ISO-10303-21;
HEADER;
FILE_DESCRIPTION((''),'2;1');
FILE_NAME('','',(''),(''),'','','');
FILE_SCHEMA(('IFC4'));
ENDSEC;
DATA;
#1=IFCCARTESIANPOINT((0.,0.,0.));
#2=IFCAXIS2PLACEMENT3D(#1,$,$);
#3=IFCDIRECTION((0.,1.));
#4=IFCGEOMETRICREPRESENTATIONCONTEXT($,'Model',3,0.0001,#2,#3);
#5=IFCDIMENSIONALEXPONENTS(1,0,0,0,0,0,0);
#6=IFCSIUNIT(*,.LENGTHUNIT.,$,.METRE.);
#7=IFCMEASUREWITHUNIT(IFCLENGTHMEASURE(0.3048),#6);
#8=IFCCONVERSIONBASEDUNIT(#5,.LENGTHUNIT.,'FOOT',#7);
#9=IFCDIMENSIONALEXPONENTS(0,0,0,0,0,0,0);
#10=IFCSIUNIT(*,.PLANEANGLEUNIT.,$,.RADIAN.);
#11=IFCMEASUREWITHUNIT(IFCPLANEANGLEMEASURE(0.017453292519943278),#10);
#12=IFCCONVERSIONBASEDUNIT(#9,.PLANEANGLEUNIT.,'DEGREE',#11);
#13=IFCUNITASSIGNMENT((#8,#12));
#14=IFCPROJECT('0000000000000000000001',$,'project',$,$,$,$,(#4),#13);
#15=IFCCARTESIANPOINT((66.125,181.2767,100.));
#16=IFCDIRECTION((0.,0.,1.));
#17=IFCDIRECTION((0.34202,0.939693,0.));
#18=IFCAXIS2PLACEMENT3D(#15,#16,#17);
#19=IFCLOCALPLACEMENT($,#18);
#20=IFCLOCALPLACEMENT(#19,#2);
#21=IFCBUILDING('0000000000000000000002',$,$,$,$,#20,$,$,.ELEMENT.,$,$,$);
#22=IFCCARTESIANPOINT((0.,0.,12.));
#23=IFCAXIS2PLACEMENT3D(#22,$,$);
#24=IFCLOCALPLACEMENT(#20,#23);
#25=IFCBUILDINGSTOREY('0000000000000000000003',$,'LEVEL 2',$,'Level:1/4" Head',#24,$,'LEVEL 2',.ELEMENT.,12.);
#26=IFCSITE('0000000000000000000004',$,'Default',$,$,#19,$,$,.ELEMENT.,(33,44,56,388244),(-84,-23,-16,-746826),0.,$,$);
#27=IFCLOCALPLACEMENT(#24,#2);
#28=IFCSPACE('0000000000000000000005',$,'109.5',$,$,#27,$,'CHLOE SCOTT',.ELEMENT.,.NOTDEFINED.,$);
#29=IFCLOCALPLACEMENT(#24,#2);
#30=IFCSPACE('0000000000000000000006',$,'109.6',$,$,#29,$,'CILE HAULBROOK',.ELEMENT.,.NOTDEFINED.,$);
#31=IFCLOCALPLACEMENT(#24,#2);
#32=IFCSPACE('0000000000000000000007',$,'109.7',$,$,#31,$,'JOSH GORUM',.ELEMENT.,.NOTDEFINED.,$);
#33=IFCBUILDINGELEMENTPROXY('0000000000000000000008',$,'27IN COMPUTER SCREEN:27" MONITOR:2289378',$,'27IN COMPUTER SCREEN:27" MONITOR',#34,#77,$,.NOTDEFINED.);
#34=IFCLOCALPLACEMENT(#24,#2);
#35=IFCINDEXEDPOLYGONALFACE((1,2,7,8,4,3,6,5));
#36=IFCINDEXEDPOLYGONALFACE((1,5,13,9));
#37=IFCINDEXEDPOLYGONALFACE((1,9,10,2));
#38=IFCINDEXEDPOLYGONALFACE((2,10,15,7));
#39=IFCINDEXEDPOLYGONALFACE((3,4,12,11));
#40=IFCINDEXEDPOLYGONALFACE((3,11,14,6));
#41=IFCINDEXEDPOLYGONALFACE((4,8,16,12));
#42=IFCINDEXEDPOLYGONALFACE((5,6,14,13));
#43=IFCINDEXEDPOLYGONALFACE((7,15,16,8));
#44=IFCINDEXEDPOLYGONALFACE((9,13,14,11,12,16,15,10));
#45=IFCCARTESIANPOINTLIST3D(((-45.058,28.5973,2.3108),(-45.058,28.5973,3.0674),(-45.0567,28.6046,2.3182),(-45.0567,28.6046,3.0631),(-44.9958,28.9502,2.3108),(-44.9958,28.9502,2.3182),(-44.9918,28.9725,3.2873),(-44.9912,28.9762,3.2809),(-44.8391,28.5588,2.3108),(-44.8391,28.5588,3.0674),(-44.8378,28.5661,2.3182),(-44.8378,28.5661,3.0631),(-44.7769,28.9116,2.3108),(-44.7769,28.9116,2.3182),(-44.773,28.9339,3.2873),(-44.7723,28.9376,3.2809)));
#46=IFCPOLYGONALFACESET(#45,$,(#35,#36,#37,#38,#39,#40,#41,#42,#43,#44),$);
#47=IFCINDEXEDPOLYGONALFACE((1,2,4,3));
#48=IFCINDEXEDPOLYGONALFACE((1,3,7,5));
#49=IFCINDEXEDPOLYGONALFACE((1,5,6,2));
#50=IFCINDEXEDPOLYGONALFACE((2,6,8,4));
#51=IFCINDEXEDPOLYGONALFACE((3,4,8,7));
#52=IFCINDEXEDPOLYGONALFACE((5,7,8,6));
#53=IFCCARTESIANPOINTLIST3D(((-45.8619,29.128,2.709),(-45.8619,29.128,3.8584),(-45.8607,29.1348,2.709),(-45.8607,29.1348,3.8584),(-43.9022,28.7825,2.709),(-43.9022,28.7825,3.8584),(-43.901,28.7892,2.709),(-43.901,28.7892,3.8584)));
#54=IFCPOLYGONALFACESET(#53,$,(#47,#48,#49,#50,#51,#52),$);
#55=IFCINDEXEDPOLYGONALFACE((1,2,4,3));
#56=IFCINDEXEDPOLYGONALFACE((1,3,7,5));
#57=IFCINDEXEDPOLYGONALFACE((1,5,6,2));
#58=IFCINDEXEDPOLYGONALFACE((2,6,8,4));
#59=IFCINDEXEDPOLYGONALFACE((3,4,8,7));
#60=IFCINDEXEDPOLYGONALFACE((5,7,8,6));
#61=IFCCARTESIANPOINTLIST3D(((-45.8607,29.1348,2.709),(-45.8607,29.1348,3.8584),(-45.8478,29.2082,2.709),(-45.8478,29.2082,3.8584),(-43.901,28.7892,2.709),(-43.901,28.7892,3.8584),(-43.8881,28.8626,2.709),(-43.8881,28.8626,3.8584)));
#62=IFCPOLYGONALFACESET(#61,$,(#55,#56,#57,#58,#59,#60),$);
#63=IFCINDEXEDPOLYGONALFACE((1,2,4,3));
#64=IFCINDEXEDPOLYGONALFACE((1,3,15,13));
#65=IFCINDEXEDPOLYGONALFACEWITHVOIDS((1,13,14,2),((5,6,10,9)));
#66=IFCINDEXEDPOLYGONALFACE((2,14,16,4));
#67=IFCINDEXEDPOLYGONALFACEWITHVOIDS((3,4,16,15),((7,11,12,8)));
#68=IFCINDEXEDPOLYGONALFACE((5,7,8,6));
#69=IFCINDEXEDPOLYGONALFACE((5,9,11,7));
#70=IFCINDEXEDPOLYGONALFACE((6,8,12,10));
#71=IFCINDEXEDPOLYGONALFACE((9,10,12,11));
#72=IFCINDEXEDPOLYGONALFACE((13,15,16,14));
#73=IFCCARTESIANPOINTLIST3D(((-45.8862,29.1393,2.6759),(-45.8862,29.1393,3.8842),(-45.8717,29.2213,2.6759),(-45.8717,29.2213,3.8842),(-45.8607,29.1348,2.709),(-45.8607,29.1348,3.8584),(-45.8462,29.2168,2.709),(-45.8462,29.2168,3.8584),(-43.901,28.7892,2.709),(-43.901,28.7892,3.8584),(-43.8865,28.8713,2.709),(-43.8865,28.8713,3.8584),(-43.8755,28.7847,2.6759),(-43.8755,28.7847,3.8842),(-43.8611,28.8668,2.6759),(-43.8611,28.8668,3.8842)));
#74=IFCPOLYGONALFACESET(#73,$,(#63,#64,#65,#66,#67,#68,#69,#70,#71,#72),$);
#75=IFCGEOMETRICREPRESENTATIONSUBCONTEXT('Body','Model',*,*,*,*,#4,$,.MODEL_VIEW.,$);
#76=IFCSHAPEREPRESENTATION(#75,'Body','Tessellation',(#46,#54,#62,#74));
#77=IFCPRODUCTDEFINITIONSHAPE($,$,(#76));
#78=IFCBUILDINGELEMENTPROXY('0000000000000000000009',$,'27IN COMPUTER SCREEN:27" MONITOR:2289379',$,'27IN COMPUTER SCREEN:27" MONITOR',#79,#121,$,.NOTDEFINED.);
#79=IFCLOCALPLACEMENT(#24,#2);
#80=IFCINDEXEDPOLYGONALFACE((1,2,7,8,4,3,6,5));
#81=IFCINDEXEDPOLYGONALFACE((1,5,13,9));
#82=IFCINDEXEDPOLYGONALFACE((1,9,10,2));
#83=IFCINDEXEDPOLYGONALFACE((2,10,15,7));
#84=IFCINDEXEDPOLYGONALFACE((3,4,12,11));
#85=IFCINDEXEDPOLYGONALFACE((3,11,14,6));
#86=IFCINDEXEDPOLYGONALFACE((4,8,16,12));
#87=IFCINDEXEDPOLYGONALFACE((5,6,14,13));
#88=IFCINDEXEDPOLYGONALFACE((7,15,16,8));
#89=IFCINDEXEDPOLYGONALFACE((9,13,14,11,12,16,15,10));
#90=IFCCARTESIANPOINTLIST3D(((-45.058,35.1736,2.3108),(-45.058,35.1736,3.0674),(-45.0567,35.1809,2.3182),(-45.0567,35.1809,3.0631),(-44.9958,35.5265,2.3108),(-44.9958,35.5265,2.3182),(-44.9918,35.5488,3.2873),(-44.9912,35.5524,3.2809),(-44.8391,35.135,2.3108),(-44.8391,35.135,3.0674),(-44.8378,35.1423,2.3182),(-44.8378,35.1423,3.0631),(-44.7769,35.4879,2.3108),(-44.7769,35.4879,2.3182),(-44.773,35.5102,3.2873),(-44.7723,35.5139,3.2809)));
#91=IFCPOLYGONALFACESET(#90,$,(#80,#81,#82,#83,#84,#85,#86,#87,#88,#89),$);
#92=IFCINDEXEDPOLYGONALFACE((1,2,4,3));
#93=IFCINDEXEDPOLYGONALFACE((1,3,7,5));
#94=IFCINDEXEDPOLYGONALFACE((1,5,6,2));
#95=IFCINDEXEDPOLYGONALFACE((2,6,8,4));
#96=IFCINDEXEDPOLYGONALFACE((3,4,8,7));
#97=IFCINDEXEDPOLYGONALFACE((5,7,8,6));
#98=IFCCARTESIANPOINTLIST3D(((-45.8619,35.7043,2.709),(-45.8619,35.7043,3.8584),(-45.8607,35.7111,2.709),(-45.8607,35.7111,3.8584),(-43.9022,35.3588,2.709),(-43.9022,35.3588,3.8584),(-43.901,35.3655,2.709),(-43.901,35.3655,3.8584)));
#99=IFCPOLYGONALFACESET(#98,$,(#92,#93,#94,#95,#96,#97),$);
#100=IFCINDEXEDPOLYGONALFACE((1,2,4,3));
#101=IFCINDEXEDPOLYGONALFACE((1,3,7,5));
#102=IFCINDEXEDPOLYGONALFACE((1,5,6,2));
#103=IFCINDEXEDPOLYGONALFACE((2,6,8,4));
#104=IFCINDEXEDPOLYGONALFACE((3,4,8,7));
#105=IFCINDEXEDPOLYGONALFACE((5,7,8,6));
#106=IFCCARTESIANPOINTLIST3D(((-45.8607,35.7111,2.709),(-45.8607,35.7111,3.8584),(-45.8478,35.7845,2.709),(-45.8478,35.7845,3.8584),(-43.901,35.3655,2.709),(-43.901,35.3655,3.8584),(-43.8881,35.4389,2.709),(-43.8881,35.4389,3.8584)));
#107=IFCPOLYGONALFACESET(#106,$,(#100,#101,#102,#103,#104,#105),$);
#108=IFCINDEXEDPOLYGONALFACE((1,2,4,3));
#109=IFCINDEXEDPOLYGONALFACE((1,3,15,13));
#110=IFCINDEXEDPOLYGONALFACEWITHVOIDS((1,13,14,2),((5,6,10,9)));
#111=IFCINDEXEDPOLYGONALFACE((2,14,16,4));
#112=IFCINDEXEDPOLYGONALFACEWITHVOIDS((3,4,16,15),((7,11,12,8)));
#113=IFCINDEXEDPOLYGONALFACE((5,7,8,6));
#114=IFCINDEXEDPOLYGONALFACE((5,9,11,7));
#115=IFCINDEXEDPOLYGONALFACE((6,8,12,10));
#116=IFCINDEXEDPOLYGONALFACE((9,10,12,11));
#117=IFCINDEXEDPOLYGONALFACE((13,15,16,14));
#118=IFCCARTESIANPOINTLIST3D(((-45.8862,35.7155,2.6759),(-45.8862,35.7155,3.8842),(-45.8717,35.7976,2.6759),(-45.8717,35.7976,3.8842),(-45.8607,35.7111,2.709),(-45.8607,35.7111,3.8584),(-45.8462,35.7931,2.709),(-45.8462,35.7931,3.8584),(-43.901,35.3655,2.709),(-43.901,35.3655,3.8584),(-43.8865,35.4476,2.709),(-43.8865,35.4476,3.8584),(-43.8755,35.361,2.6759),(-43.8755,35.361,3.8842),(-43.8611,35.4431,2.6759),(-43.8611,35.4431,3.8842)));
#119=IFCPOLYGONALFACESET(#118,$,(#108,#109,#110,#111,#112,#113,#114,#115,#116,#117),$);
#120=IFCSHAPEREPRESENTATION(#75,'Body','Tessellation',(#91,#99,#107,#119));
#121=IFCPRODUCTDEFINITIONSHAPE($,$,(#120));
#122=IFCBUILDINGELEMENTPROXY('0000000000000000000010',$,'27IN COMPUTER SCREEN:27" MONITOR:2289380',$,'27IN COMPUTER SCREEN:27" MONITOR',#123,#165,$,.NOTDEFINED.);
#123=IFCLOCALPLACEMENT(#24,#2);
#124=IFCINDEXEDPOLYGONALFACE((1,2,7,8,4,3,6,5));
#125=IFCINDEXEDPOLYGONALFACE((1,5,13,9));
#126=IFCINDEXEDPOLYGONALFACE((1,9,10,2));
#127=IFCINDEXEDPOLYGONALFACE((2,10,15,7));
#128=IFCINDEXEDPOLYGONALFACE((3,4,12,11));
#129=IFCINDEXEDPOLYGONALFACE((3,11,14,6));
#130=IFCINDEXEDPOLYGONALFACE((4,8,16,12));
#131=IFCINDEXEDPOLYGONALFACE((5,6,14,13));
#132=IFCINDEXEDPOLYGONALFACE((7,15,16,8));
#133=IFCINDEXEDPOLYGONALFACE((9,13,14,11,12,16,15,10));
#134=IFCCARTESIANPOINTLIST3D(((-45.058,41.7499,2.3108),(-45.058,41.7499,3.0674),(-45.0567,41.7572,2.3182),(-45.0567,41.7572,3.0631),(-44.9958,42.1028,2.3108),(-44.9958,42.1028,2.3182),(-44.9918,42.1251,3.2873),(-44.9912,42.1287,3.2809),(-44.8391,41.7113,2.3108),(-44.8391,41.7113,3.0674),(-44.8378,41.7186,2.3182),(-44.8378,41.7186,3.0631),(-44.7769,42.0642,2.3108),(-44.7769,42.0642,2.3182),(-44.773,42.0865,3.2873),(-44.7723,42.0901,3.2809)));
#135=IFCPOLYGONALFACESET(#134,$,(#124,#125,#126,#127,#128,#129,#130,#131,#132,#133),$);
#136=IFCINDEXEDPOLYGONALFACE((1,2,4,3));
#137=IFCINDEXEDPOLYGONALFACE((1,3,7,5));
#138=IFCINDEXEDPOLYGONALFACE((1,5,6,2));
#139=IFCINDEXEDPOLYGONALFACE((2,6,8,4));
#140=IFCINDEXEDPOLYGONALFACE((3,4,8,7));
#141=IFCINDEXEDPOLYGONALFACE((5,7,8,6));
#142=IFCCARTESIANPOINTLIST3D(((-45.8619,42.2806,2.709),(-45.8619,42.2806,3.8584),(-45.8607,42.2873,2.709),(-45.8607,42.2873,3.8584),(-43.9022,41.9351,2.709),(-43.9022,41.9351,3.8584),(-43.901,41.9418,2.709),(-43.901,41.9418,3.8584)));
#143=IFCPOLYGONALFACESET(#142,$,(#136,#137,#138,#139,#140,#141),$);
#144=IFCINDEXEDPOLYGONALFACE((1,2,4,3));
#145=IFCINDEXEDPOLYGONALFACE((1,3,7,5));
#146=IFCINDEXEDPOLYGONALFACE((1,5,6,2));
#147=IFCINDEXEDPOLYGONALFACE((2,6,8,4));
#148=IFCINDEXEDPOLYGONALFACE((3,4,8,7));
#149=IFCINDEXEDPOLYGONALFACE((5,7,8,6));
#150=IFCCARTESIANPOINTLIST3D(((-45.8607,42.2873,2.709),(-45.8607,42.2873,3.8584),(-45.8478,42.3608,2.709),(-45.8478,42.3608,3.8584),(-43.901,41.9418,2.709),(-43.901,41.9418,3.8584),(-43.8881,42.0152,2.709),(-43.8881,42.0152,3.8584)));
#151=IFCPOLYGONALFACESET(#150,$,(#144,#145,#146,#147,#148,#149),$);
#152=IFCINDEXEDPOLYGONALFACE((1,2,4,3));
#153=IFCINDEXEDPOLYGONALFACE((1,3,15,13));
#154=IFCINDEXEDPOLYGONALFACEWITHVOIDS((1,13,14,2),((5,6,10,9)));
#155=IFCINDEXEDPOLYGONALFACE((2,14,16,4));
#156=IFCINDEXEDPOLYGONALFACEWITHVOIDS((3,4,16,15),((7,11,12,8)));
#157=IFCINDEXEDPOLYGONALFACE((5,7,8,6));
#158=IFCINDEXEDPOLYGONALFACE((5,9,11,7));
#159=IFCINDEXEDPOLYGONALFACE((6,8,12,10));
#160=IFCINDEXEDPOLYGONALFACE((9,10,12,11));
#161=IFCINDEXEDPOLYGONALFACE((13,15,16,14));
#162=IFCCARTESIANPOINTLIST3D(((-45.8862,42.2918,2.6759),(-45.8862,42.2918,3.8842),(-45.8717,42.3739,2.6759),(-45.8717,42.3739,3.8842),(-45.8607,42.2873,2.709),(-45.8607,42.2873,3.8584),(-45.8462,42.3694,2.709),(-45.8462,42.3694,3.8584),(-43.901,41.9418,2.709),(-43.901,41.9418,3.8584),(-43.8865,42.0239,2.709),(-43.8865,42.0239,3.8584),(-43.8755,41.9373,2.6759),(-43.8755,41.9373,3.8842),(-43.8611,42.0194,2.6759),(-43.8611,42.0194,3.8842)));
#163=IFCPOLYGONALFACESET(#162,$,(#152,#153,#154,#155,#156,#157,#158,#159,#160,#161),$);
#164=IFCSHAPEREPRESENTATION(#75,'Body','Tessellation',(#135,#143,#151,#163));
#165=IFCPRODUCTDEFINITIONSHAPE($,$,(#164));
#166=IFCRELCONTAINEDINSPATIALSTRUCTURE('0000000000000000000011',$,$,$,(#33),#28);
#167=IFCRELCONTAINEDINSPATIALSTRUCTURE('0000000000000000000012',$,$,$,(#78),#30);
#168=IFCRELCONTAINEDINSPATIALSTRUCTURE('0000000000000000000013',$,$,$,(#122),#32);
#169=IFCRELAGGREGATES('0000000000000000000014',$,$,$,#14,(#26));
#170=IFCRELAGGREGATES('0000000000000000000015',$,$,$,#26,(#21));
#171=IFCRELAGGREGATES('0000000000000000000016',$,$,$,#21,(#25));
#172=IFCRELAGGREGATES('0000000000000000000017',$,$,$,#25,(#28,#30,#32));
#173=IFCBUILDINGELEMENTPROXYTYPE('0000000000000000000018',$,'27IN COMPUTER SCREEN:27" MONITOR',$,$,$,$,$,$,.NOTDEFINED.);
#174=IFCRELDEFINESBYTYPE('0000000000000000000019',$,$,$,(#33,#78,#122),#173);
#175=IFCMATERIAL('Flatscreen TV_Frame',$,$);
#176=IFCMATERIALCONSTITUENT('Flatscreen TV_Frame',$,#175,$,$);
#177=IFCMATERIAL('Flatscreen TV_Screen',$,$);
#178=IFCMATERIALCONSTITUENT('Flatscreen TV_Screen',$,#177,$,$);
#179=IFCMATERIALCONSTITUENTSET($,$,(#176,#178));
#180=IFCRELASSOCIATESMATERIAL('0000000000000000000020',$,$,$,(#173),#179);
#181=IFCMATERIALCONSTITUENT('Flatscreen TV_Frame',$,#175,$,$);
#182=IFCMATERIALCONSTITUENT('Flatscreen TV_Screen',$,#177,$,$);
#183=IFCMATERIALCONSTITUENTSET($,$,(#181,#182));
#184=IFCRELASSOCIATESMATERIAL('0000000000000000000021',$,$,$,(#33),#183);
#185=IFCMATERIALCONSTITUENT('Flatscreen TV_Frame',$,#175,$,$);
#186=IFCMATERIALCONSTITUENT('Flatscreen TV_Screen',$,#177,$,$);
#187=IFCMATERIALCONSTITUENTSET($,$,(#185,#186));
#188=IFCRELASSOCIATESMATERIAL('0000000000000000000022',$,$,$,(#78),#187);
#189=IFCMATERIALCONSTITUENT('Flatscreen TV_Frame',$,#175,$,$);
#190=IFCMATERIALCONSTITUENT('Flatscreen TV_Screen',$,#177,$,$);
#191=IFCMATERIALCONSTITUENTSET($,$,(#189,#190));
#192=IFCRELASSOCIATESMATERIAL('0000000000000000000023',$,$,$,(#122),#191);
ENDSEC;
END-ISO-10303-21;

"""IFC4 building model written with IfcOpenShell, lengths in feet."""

from ifc_helpers import new_model, entity, si_unit, converted_unit, direction, frame, frame_2d, origin, origin_2d_with_axis, place, context, subcontext, project, spatial, polyline, rectangle, outline, extrude, source, transform, mapped, material, constituent, constituent_set, type_object, type_shapes, element, save


model = new_model("IFC4")

# Units and contexts
model_context = context("Model", 3, precision=0.0001, world=origin(), true_north=direction((0.0, 1.0)))
body_context = subcontext(model_context, "Body", "Model", "MODEL_VIEW")
ifc_project = project(units=[converted_unit("LENGTHUNIT", "FOOT", entity("IfcLengthMeasure", 0.3048), si_unit("LENGTHUNIT", "METRE"), dimensions=[1, 0, 0, 0, 0, 0, 0]), converted_unit("PLANEANGLEUNIT", "DEGREE", entity("IfcPlaneAngleMeasure", 0.017453292519943278), si_unit("PLANEANGLEUNIT", "RADIAN"), dimensions=[0, 0, 0, 0, 0, 0, 0])], contexts=[model_context])

# Site, building, storey
site_placement = place(None, frame((66.125, 181.2767, 100.0), z_axis=(0.0, 0.0, 1.0), x_axis=(0.34202, 0.939693, 0.0)))
site = spatial("IfcSite", under=ifc_project, at=site_placement, Name="Default", CompositionType="ELEMENT", RefLatitude=(33, 44, 56, 388244), RefLongitude=(-84, -23, -16, -746826), RefElevation=0.0)
building_placement = place(site_placement, origin())
building = spatial("IfcBuilding", under=site, at=building_placement, CompositionType="ELEMENT")
storey_placement = place(building_placement, frame((0.0, 0.0, 12.0)))
storey = spatial("IfcBuildingStorey", under=building, at=storey_placement, Name="LEVEL 2", ObjectType="Level:1/4\" Head", LongName="LEVEL 2", CompositionType="ELEMENT", Elevation=12.0)

# Shared definitions
space_1_placement = place(storey_placement, origin())
space_1 = spatial("IfcSpace", under=storey, at=space_1_placement, Name="109.5", LongName="CHLOE SCOTT", CompositionType="ELEMENT", PredefinedType="NOTDEFINED")

# Shared definitions
space_2_placement = place(storey_placement, origin())
space_2 = spatial("IfcSpace", under=storey, at=space_2_placement, Name="109.6", LongName="CILE HAULBROOK", CompositionType="ELEMENT", PredefinedType="NOTDEFINED")

# Shared definitions
space_3_placement = place(storey_placement, origin())
space_3 = spatial("IfcSpace", under=storey, at=space_3_placement, Name="109.7", LongName="JOSH GORUM", CompositionType="ELEMENT", PredefinedType="NOTDEFINED")

# Building element proxies
ifc_material_1 = material(Name="Flatscreen TV_Frame")
ifc_material_2 = material(Name="Flatscreen TV_Screen")
ifc_constituent_1 = constituent(ifc_material_1, Name="Flatscreen TV_Frame")
ifc_constituent_2 = constituent(ifc_material_2, Name="Flatscreen TV_Screen")
ifc_constituent_set_1 = constituent_set(constituents=[ifc_constituent_1, ifc_constituent_2])
building_element_proxy_type_1 = type_object("IfcBuildingElementProxyType", Name="27IN COMPUTER SCREEN:27\" MONITOR", PredefinedType="NOTDEFINED", material=ifc_constituent_set_1)
shared_shape_1 = source(origin(), body_context, "Body", "SweptSolid", [
    extrude(outline(polyline([(-0.4392, -0.3657), (-0.4392, -0.3731), (0.0007, -0.3731), (0.379, 0.2821), (0.0686, 0.4613), (0.0649, 0.4548), (0.3688, 0.2794), (-0.0036, -0.3657), (-0.4392, -0.3657)])), frame((-0.1111, -0.0264, 0.0687), z_axis=(-1.0, 0.0, 0.0), x_axis=(0.0, 0.866025, -0.5)), (0.0, 0.0, -1.0), 0.2222),
    extrude(rectangle(XDim=0.0068, YDim=1.9899, at=origin_2d_with_axis()), frame((0.0, -0.2257, 0.0331), z_axis=(0.0, 0.0, 1.0), x_axis=(0.0, 1.0, 0.0)), (0.0, 0.0, 1.0), 1.1493),
    extrude(rectangle(XDim=0.0746, YDim=1.9899, at=frame_2d((0.0, 0.0), x_axis=(1.0, 0.0))), frame((0.0, -0.2664, 0.0331), z_axis=(0.0, 0.0, 1.0), x_axis=(0.0, 1.0, 0.0)), (0.0, 0.0, 1.0), 1.1493),
    extrude(outline(polyline([(-0.6042, -1.0208), (0.6042, -1.0208), (0.6042, 1.0208), (-0.6042, 1.0208), (-0.6042, -1.0208)]), holes=[polyline([(-0.5783, -0.995), (-0.5783, 0.995), (0.571, 0.995), (0.571, -0.995), (-0.5783, -0.995)])]), frame((0.0, -0.3125, 0.6042), z_axis=(0.0, 1.0, 0.0), x_axis=(0.0, 0.0, -1.0)), (0.0, 0.0, 1.0), 0.0833),
])
type_shapes(building_element_proxy_type_1, [shared_shape_1])
ifc_constituent_3 = constituent(ifc_material_1, Name="Flatscreen TV_Frame")
ifc_constituent_4 = constituent(ifc_material_2, Name="Flatscreen TV_Screen")
ifc_constituent_set_2 = constituent_set(constituents=[ifc_constituent_3, ifc_constituent_4])
proxy_1_placement = place(space_1_placement, frame((-44.9207, 28.7363, 2.6759), z_axis=(0.0, 0.0, 1.0), x_axis=(-0.984808, 0.173648, 0.0)))
element("IfcBuildingElementProxy", 1, at=proxy_1_placement, inside=space_1, type_object=building_element_proxy_type_1, material=ifc_constituent_set_2, Name="27IN COMPUTER SCREEN:27\" MONITOR:2289378", ObjectType="27IN COMPUTER SCREEN:27\" MONITOR", PredefinedType="NOTDEFINED", context=body_context, shape_type="MappedRepresentation", body=[
    mapped(shared_shape_1, transform((0.0, 0.0, 0.0), scale=1.0)),
])
ifc_constituent_5 = constituent(ifc_material_1, Name="Flatscreen TV_Frame")
ifc_constituent_6 = constituent(ifc_material_2, Name="Flatscreen TV_Screen")
ifc_constituent_set_3 = constituent_set(constituents=[ifc_constituent_5, ifc_constituent_6])
proxy_2_placement = place(space_2_placement, frame((-44.9207, 35.3126, 2.6759), z_axis=(0.0, 0.0, 1.0), x_axis=(-0.984808, 0.173648, 0.0)))
element("IfcBuildingElementProxy", 2, at=proxy_2_placement, inside=space_2, type_object=building_element_proxy_type_1, material=ifc_constituent_set_3, Name="27IN COMPUTER SCREEN:27\" MONITOR:2289379", ObjectType="27IN COMPUTER SCREEN:27\" MONITOR", PredefinedType="NOTDEFINED", context=body_context, shape_type="MappedRepresentation", body=[
    mapped(shared_shape_1, transform((0.0, 0.0, 0.0), scale=1.0)),
])
ifc_constituent_7 = constituent(ifc_material_1, Name="Flatscreen TV_Frame")
ifc_constituent_8 = constituent(ifc_material_2, Name="Flatscreen TV_Screen")
ifc_constituent_set_4 = constituent_set(constituents=[ifc_constituent_7, ifc_constituent_8])
proxy_3_placement = place(space_3_placement, frame((-44.9207, 41.8889, 2.6759), z_axis=(0.0, 0.0, 1.0), x_axis=(-0.984808, 0.173648, 0.0)))
element("IfcBuildingElementProxy", 3, at=proxy_3_placement, inside=space_3, type_object=building_element_proxy_type_1, material=ifc_constituent_set_4, Name="27IN COMPUTER SCREEN:27\" MONITOR:2289380", ObjectType="27IN COMPUTER SCREEN:27\" MONITOR", PredefinedType="NOTDEFINED", context=body_context, shape_type="MappedRepresentation", body=[
    mapped(shared_shape_1, transform((0.0, 0.0, 0.0), scale=1.0)),
])

save(model, "model.ifc")
